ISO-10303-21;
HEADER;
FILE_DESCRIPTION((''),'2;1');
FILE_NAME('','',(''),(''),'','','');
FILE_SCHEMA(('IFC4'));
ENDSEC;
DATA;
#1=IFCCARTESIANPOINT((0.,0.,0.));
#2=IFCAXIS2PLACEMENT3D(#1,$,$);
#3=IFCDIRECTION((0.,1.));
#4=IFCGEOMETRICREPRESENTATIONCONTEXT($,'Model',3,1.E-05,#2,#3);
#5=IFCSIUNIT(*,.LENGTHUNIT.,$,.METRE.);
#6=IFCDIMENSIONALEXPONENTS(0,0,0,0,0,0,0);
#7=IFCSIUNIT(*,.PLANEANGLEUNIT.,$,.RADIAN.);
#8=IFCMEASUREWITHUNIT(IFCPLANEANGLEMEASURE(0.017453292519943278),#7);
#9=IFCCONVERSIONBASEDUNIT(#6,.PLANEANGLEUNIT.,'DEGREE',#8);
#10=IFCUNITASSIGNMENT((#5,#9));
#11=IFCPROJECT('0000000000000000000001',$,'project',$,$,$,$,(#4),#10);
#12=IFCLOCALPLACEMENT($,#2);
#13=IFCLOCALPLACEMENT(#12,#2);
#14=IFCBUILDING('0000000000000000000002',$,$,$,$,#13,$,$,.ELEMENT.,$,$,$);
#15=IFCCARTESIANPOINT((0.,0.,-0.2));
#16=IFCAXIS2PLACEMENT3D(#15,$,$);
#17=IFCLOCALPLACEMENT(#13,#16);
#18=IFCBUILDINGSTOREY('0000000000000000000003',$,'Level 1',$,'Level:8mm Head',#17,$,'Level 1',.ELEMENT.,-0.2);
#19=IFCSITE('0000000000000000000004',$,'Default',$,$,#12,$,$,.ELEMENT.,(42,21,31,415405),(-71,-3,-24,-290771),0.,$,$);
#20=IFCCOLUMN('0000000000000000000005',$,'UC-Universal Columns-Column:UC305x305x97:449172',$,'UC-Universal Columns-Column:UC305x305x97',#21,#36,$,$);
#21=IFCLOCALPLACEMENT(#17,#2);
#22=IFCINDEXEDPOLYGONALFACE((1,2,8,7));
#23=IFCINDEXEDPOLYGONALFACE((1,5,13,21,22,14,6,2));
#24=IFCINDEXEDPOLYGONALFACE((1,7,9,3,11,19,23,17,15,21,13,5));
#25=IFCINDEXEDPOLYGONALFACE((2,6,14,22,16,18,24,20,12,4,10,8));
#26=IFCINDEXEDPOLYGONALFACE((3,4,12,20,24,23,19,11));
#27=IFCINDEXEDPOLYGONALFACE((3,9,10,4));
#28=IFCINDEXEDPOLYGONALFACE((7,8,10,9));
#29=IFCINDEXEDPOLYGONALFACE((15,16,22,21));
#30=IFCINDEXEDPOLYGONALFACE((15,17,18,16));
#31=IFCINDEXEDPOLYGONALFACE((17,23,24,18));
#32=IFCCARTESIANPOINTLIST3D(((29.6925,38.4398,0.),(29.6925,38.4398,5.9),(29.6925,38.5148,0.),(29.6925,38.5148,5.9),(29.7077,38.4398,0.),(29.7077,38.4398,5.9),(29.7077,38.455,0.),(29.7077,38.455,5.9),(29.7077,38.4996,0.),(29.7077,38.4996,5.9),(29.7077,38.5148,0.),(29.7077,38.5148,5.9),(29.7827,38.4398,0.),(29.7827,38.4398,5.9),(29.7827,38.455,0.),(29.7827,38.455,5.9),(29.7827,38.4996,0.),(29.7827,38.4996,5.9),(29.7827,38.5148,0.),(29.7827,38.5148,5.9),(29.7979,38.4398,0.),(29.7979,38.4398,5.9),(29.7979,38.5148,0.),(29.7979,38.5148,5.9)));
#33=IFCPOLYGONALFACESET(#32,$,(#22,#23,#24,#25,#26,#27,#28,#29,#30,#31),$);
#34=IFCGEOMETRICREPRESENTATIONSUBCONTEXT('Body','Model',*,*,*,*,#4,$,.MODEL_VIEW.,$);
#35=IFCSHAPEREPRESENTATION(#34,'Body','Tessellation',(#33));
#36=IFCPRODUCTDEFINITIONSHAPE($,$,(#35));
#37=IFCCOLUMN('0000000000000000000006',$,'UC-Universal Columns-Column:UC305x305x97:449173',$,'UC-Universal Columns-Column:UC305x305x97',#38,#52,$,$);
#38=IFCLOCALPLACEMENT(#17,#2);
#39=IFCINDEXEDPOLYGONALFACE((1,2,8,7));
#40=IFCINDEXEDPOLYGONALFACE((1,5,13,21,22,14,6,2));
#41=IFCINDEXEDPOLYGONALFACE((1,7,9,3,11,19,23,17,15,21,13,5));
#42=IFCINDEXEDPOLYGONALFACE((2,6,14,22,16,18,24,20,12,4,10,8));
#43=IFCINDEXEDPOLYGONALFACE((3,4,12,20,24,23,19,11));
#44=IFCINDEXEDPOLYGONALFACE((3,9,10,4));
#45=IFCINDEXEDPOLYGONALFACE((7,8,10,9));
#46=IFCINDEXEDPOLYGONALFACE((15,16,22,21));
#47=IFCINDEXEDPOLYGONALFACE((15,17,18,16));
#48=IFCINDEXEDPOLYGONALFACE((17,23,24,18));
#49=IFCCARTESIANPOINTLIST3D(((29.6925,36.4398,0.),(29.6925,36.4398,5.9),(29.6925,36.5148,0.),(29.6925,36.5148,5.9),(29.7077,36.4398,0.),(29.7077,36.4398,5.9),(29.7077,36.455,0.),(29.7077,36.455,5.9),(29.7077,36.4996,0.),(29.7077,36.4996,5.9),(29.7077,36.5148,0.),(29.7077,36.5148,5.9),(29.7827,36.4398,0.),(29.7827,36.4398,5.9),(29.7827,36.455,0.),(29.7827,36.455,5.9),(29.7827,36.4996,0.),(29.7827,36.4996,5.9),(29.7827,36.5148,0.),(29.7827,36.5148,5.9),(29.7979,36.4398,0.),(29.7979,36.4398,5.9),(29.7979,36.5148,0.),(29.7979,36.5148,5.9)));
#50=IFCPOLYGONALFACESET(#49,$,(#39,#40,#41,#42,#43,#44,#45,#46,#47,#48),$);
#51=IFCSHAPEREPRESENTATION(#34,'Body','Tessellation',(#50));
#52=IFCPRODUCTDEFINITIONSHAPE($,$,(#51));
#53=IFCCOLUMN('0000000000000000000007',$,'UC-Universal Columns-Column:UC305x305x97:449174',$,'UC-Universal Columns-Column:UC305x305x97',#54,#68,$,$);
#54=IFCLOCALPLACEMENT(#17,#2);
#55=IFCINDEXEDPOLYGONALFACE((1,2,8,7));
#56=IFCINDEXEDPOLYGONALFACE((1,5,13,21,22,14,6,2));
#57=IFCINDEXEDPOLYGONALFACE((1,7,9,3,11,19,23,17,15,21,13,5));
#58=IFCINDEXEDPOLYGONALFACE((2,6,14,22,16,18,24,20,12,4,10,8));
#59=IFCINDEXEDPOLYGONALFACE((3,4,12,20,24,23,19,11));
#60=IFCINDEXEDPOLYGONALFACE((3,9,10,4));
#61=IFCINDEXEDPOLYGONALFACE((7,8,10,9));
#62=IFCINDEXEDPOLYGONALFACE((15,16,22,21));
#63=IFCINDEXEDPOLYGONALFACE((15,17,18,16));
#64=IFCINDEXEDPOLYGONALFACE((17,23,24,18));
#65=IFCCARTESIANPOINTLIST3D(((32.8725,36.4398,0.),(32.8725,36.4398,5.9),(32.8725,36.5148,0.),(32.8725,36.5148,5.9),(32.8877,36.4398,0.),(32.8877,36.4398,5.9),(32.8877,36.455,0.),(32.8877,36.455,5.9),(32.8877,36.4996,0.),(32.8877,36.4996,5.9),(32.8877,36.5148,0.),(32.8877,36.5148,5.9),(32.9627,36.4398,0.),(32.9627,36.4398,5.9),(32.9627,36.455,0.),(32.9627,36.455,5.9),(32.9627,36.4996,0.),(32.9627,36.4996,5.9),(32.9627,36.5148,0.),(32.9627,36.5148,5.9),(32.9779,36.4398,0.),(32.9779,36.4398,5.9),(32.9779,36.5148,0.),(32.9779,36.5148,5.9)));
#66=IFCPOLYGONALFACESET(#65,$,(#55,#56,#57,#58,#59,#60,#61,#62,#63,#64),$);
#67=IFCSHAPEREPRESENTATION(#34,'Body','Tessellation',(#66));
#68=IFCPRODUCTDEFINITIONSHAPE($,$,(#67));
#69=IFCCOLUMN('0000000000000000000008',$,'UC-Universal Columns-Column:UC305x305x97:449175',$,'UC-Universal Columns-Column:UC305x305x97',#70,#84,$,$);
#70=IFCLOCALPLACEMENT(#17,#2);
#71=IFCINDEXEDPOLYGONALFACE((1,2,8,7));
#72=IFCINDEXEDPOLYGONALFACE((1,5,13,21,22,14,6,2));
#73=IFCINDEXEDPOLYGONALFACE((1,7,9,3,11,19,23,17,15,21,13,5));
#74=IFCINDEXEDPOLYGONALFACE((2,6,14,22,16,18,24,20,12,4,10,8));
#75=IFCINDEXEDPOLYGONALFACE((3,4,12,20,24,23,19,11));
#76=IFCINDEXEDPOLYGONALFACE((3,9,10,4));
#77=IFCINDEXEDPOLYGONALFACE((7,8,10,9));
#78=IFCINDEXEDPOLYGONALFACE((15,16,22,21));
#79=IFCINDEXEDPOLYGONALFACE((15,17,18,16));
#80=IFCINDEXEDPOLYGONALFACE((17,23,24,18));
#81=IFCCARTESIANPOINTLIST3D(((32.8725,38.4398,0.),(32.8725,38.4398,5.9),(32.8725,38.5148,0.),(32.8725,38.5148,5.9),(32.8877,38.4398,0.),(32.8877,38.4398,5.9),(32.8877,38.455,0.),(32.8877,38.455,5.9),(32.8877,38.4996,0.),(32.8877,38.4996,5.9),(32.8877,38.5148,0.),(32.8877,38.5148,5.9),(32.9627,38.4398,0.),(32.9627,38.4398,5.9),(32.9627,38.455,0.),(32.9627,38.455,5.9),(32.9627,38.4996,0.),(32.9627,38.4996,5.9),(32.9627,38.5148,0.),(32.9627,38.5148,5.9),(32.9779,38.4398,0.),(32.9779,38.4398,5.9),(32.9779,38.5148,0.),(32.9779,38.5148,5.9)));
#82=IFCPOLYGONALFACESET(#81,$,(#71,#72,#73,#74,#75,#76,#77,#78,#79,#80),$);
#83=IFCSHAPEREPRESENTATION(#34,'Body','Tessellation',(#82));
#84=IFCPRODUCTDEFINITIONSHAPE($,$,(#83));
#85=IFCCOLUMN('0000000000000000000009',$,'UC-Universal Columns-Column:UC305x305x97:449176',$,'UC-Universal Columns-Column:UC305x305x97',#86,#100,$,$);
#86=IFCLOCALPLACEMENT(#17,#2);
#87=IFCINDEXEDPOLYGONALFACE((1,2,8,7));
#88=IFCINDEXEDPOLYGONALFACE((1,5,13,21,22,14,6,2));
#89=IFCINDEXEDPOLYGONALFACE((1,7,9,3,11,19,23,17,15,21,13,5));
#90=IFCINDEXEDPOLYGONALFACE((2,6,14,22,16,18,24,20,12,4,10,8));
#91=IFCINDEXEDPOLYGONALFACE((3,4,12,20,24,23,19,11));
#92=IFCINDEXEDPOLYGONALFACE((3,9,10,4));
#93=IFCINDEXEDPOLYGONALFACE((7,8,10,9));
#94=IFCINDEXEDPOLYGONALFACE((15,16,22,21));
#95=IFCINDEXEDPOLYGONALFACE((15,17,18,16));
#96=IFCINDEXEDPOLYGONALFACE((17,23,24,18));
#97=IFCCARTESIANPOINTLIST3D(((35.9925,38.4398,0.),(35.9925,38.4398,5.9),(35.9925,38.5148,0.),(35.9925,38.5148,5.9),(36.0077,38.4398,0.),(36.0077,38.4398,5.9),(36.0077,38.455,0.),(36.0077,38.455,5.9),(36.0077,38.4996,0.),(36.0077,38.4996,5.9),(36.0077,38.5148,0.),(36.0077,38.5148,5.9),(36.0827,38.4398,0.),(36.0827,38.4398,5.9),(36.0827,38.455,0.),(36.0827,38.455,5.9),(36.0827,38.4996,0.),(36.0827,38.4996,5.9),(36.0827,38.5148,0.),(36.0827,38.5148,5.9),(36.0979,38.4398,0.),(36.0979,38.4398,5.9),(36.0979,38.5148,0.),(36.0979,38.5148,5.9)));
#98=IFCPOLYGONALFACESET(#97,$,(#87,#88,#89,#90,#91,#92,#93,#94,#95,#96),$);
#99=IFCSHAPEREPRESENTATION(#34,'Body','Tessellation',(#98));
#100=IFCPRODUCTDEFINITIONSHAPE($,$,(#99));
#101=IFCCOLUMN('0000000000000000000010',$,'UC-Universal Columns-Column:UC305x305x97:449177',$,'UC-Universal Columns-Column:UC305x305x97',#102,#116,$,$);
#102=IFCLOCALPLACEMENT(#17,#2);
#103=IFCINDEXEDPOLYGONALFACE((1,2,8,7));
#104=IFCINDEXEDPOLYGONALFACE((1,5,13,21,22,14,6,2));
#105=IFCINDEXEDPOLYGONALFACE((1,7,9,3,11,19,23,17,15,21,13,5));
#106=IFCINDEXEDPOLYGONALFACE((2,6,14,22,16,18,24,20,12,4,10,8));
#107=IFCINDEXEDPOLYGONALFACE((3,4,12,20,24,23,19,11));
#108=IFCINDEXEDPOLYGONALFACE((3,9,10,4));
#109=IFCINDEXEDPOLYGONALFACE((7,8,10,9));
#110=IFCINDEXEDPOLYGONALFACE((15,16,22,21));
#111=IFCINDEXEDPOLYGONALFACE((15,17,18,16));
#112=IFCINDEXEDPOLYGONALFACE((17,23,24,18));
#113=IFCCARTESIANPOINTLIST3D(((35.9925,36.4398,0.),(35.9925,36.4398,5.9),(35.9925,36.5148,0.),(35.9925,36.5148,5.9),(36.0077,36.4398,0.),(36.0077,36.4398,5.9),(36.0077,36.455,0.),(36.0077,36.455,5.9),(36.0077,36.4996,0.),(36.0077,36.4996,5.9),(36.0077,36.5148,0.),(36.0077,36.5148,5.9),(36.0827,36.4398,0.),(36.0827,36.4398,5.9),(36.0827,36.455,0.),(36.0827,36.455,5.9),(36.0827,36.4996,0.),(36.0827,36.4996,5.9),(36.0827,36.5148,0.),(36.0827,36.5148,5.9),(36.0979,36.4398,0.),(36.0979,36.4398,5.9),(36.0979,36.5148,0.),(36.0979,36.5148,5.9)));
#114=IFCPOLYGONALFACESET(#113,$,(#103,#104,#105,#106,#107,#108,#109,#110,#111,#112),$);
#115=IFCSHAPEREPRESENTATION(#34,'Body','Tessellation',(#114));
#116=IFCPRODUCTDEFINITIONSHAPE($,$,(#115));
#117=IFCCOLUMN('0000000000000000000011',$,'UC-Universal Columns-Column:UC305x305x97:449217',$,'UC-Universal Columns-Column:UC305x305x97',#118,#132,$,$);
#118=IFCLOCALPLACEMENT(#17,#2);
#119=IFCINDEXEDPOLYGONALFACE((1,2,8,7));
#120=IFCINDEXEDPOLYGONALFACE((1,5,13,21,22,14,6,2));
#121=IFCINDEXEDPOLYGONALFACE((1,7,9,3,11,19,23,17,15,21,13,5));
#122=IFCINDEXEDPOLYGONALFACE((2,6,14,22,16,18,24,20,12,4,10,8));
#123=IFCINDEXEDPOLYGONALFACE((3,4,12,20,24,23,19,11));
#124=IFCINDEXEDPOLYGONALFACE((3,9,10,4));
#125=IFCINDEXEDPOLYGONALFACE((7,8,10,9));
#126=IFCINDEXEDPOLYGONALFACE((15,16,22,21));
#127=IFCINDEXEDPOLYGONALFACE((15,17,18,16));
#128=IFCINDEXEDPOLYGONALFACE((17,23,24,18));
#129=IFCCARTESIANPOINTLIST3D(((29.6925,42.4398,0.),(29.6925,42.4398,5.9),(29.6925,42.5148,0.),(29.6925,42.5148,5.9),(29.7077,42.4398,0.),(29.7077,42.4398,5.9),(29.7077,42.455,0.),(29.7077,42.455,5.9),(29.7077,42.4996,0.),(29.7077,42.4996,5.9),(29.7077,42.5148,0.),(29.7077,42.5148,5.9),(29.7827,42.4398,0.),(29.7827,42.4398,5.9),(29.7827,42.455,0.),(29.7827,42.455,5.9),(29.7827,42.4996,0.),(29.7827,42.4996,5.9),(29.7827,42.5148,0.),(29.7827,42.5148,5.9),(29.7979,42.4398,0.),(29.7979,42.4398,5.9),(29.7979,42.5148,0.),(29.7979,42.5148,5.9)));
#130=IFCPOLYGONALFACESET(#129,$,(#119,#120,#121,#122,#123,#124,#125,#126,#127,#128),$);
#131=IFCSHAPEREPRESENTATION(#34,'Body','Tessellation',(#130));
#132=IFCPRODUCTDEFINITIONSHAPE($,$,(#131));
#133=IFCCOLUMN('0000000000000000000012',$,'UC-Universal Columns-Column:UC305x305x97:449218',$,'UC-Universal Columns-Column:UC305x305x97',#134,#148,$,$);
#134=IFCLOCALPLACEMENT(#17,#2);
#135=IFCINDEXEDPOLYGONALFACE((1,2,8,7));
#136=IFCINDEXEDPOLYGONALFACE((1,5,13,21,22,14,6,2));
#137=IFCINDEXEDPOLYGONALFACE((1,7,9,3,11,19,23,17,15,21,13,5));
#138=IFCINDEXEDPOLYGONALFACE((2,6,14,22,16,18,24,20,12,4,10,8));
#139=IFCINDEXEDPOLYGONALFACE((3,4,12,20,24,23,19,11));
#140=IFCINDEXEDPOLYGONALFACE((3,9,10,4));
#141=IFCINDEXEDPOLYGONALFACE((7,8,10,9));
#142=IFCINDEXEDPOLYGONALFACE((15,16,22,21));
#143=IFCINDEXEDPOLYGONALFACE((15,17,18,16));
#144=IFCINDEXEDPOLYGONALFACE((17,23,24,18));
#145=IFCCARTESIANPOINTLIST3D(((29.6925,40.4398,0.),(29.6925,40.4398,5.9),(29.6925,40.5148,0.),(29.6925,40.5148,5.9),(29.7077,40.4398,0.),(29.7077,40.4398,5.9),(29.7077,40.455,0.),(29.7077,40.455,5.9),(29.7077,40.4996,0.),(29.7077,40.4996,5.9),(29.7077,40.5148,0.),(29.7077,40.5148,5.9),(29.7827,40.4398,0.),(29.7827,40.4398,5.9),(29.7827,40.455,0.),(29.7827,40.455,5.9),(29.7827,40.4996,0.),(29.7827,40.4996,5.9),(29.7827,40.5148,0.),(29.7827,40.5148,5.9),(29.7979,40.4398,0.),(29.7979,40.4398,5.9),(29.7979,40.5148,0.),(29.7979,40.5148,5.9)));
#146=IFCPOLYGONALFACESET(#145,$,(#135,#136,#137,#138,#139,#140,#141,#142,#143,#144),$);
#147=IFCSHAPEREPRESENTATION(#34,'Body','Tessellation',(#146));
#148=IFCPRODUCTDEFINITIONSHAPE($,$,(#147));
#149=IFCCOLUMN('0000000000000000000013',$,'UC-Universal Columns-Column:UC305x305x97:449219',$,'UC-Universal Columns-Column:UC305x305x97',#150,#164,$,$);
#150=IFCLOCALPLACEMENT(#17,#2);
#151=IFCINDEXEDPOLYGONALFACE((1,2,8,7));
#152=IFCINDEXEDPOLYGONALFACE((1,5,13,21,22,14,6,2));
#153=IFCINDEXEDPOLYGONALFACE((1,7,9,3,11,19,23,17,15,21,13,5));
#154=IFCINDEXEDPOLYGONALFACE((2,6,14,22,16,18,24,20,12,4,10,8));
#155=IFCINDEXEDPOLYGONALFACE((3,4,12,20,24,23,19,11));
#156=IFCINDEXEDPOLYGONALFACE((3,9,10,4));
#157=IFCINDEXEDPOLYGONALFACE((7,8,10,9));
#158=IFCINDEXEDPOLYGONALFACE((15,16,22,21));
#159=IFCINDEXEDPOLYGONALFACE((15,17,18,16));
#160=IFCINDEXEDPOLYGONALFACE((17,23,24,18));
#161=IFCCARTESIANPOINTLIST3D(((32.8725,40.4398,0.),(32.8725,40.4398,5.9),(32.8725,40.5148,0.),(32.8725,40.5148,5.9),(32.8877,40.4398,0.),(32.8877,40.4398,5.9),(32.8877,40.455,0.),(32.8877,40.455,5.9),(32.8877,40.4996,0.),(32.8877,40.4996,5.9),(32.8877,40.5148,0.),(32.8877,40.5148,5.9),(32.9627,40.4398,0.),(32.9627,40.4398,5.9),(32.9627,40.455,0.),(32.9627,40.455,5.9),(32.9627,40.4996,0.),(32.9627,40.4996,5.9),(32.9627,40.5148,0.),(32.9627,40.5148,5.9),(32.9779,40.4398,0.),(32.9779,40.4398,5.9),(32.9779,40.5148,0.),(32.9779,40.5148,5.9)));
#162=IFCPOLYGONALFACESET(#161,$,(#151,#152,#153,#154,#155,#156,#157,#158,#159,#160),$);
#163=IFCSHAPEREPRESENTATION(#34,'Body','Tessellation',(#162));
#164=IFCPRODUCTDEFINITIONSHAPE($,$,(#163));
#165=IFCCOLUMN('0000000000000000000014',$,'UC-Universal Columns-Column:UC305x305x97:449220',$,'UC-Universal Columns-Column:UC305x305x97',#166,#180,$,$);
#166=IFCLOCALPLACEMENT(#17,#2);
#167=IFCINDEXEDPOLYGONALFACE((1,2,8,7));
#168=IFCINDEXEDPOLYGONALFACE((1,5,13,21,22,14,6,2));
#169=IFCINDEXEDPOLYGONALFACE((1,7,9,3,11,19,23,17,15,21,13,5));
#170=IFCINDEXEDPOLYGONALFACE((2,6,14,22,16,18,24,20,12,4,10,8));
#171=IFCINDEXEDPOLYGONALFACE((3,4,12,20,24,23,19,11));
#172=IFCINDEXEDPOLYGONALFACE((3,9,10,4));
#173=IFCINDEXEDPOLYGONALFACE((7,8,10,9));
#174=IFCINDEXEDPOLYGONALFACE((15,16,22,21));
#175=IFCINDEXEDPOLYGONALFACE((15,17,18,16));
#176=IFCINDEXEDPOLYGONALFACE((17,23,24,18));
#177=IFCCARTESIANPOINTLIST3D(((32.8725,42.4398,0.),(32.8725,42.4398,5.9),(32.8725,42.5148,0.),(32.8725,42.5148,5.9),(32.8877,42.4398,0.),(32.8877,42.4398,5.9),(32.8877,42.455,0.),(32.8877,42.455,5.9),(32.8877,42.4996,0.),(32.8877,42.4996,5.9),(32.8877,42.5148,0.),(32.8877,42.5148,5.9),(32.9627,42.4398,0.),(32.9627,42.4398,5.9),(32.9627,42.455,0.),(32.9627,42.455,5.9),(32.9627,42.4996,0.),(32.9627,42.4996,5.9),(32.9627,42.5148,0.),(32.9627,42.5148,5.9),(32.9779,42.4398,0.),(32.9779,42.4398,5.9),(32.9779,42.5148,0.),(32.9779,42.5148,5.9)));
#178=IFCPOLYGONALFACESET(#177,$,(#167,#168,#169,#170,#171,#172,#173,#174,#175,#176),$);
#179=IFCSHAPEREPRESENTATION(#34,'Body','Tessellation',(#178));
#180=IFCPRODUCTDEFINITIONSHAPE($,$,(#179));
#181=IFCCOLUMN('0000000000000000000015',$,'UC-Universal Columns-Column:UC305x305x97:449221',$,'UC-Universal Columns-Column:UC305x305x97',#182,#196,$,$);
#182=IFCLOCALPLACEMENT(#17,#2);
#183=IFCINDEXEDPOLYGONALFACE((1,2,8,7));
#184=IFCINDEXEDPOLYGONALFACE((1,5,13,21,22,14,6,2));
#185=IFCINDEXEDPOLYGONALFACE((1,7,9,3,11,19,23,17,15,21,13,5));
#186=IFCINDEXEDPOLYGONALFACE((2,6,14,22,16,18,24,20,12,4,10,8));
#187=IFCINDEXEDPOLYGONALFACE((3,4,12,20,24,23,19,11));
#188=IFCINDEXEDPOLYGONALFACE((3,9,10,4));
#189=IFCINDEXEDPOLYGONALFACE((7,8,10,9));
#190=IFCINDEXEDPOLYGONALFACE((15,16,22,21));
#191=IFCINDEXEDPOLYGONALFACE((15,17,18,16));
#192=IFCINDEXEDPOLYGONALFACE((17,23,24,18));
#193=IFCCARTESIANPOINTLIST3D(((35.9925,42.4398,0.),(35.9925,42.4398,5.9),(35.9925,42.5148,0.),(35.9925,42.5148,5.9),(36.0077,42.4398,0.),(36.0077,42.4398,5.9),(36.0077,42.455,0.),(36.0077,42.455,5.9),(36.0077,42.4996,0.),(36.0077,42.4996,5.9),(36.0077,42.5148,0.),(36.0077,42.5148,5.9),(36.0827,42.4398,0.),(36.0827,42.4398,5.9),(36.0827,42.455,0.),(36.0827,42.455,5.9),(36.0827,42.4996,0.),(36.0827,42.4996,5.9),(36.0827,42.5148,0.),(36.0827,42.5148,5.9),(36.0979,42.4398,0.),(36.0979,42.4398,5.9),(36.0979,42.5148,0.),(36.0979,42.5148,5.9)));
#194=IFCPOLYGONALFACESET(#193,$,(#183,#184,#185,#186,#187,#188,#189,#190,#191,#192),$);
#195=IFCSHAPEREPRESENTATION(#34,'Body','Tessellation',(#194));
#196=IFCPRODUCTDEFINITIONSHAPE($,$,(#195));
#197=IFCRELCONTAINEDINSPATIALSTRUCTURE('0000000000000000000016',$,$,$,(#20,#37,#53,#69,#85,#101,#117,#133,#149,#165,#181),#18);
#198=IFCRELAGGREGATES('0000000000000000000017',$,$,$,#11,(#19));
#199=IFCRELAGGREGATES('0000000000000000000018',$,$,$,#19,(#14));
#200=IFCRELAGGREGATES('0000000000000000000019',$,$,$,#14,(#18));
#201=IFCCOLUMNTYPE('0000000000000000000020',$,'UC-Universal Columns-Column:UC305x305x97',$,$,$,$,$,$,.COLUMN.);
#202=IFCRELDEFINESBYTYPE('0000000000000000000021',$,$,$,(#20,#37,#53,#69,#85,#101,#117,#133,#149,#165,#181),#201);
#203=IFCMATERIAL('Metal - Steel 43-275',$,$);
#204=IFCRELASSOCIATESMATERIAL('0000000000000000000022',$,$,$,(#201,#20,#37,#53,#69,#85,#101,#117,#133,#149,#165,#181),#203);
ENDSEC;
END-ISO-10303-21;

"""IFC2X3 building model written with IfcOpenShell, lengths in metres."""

from ifc_helpers import new_model, entity, si_unit, converted_unit, direction, frame, frame_2d, origin, place, context, subcontext, project, spatial, polyline, circle_curve, parameter, trimmed, segment, composite_curve, outline, extrude, source, transform, mapped, material, type_object, type_shapes, element, save


model = new_model("IFC2X3")

# Units and contexts
model_context = context("Model", 3, precision=1e-05, world=origin(), true_north=direction((0.0, 1.0)))
body_context = subcontext(model_context, "Body", "Model", "MODEL_VIEW")
ifc_project = project(units=[si_unit("LENGTHUNIT", "METRE"), converted_unit("PLANEANGLEUNIT", "DEGREE", entity("IfcPlaneAngleMeasure", 0.017453292519943278), si_unit("PLANEANGLEUNIT", "RADIAN"), dimensions=[0, 0, 0, 0, 0, 0, 0])], contexts=[model_context])

# Site, building, storey
site_placement = place(None, origin())
site = spatial("IfcSite", under=ifc_project, at=site_placement, Name="Default", CompositionType="ELEMENT", RefLatitude=(42, 21, 31, 415405), RefLongitude=(-71, -3, -24, -290771), RefElevation=0.0)
building_placement = place(site_placement, origin())
building = spatial("IfcBuilding", under=site, at=building_placement, CompositionType="ELEMENT")
storey_placement = place(building_placement, frame((0.0, 0.0, -0.2)))
storey = spatial("IfcBuildingStorey", under=building, at=storey_placement, Name="Level 1", ObjectType="Level:8mm Head", LongName="Level 1", CompositionType="ELEMENT", Elevation=-0.2)

# Columns
ifc_material = material(Name="Metal - Steel 43-275")
column_type = type_object("IfcColumnType", Name="UC-Universal Columns-Column:UC305x305x97", PredefinedType="COLUMN", material=ifc_material)
shared_shape = source(origin(), body_context, "Body", "SweptSolid", [
    extrude(outline(composite_curve([segment(polyline([(-0.0375, -0.0375), (0.0375, -0.0375)]), True, "CONTINUOUS"), segment(polyline([(0.0375, -0.0375), (0.0527, -0.0375)]), True, "CONTINUOUS"), segment(trimmed(circle_curve(frame_2d((0.0527, -0.0223), x_axis=(-1.0, 0.0)), 0.0152), [parameter(0.0)], [parameter(90.0)], True, "PARAMETER"), False, "CONTINUOUS"), segment(polyline([(0.0375, -0.0223), (0.0375, 0.0223)]), True, "CONTINUOUS"), segment(trimmed(circle_curve(frame_2d((0.0527, 0.0223), x_axis=(-1.0, 0.0)), 0.0152), [parameter(270.0)], [parameter(0.0)], True, "PARAMETER"), False, "CONTINUOUS"), segment(polyline([(0.0527, 0.0375), (0.0375, 0.0375)]), True, "CONTINUOUS"), segment(polyline([(0.0375, 0.0375), (-0.0375, 0.0375)]), True, "CONTINUOUS"), segment(polyline([(-0.0375, 0.0375), (-0.0527, 0.0375)]), True, "CONTINUOUS"), segment(trimmed(circle_curve(frame_2d((-0.0527, 0.0223), x_axis=(-1.0, 0.0)), 0.0152), [parameter(180.0)], [parameter(270.0)], True, "PARAMETER"), False, "CONTINUOUS"), segment(polyline([(-0.0375, 0.0223), (-0.0375, -0.0223)]), True, "CONTINUOUS"), segment(trimmed(circle_curve(frame_2d((-0.0527, -0.0223), x_axis=(-1.0, 0.0)), 0.0152), [parameter(90.0)], [parameter(180.0)], True, "PARAMETER"), False, "CONTINUOUS"), segment(polyline([(-0.0527, -0.0375), (-0.0375, -0.0375)]), True, "CONTINUOUS")], self_intersect=False)), frame((0.0, 0.0, -0.2), z_axis=(0.0, 0.0, 1.0), x_axis=(-1.0, 0.0, 0.0)), (0.0, 0.0, 1.0), 5.9),
])
type_shapes(column_type, [shared_shape])
for number, where, z_axis, x_axis, name in (
    (1, (29.7452, 38.4773, 0.2), (0.0, 0.0, 1.0), (-1.0, 0.0, 0.0), "UC-Universal Columns-Column:UC305x305x97:449172"),
    (2, (29.7452, 36.4773, 0.2), (0.0, 0.0, 1.0), (-1.0, 0.0, 0.0), "UC-Universal Columns-Column:UC305x305x97:449173"),
    (3, (32.9252, 36.4773, 0.2), (0.0, 0.0, 1.0), (-1.0, 0.0, 0.0), "UC-Universal Columns-Column:UC305x305x97:449174"),
    (4, (32.9252, 38.4773, 0.2), (0.0, 0.0, 1.0), (-1.0, 0.0, 0.0), "UC-Universal Columns-Column:UC305x305x97:449175"),
    (5, (36.0452, 38.4773, 0.2), (0.0, 0.0, 1.0), (-1.0, 0.0, 0.0), "UC-Universal Columns-Column:UC305x305x97:449176"),
    (6, (36.0452, 36.4773, 0.2), (0.0, 0.0, 1.0), (-1.0, 0.0, 0.0), "UC-Universal Columns-Column:UC305x305x97:449177"),
    (7, (29.7452, 42.4773, 0.2), (0.0, 0.0, 1.0), (-1.0, 0.0, 0.0), "UC-Universal Columns-Column:UC305x305x97:449217"),
    (8, (29.7452, 40.4773, 0.2), (0.0, 0.0, 1.0), (-1.0, 0.0, 0.0), "UC-Universal Columns-Column:UC305x305x97:449218"),
    (9, (32.9252, 40.4773, 0.2), (0.0, 0.0, 1.0), (-1.0, 0.0, 0.0), "UC-Universal Columns-Column:UC305x305x97:449219"),
    (10, (32.9252, 42.4773, 0.2), (0.0, 0.0, 1.0), (-1.0, 0.0, 0.0), "UC-Universal Columns-Column:UC305x305x97:449220"),
    (11, (36.0452, 42.4773, 0.2), (0.0, 0.0, 1.0), (-1.0, 0.0, 0.0), "UC-Universal Columns-Column:UC305x305x97:449221"),
):
    element("IfcColumn", number, at=place(storey_placement, frame(where, z_axis=z_axis, x_axis=x_axis)), inside=storey, type_object=column_type, material=ifc_material, Name=name, ObjectType="UC-Universal Columns-Column:UC305x305x97", context=body_context, shape_type="MappedRepresentation", body=[
        mapped(shared_shape, transform((0.0, 0.0, 0.0), scale=1.0)),
    ])

save(model, "model.ifc")
